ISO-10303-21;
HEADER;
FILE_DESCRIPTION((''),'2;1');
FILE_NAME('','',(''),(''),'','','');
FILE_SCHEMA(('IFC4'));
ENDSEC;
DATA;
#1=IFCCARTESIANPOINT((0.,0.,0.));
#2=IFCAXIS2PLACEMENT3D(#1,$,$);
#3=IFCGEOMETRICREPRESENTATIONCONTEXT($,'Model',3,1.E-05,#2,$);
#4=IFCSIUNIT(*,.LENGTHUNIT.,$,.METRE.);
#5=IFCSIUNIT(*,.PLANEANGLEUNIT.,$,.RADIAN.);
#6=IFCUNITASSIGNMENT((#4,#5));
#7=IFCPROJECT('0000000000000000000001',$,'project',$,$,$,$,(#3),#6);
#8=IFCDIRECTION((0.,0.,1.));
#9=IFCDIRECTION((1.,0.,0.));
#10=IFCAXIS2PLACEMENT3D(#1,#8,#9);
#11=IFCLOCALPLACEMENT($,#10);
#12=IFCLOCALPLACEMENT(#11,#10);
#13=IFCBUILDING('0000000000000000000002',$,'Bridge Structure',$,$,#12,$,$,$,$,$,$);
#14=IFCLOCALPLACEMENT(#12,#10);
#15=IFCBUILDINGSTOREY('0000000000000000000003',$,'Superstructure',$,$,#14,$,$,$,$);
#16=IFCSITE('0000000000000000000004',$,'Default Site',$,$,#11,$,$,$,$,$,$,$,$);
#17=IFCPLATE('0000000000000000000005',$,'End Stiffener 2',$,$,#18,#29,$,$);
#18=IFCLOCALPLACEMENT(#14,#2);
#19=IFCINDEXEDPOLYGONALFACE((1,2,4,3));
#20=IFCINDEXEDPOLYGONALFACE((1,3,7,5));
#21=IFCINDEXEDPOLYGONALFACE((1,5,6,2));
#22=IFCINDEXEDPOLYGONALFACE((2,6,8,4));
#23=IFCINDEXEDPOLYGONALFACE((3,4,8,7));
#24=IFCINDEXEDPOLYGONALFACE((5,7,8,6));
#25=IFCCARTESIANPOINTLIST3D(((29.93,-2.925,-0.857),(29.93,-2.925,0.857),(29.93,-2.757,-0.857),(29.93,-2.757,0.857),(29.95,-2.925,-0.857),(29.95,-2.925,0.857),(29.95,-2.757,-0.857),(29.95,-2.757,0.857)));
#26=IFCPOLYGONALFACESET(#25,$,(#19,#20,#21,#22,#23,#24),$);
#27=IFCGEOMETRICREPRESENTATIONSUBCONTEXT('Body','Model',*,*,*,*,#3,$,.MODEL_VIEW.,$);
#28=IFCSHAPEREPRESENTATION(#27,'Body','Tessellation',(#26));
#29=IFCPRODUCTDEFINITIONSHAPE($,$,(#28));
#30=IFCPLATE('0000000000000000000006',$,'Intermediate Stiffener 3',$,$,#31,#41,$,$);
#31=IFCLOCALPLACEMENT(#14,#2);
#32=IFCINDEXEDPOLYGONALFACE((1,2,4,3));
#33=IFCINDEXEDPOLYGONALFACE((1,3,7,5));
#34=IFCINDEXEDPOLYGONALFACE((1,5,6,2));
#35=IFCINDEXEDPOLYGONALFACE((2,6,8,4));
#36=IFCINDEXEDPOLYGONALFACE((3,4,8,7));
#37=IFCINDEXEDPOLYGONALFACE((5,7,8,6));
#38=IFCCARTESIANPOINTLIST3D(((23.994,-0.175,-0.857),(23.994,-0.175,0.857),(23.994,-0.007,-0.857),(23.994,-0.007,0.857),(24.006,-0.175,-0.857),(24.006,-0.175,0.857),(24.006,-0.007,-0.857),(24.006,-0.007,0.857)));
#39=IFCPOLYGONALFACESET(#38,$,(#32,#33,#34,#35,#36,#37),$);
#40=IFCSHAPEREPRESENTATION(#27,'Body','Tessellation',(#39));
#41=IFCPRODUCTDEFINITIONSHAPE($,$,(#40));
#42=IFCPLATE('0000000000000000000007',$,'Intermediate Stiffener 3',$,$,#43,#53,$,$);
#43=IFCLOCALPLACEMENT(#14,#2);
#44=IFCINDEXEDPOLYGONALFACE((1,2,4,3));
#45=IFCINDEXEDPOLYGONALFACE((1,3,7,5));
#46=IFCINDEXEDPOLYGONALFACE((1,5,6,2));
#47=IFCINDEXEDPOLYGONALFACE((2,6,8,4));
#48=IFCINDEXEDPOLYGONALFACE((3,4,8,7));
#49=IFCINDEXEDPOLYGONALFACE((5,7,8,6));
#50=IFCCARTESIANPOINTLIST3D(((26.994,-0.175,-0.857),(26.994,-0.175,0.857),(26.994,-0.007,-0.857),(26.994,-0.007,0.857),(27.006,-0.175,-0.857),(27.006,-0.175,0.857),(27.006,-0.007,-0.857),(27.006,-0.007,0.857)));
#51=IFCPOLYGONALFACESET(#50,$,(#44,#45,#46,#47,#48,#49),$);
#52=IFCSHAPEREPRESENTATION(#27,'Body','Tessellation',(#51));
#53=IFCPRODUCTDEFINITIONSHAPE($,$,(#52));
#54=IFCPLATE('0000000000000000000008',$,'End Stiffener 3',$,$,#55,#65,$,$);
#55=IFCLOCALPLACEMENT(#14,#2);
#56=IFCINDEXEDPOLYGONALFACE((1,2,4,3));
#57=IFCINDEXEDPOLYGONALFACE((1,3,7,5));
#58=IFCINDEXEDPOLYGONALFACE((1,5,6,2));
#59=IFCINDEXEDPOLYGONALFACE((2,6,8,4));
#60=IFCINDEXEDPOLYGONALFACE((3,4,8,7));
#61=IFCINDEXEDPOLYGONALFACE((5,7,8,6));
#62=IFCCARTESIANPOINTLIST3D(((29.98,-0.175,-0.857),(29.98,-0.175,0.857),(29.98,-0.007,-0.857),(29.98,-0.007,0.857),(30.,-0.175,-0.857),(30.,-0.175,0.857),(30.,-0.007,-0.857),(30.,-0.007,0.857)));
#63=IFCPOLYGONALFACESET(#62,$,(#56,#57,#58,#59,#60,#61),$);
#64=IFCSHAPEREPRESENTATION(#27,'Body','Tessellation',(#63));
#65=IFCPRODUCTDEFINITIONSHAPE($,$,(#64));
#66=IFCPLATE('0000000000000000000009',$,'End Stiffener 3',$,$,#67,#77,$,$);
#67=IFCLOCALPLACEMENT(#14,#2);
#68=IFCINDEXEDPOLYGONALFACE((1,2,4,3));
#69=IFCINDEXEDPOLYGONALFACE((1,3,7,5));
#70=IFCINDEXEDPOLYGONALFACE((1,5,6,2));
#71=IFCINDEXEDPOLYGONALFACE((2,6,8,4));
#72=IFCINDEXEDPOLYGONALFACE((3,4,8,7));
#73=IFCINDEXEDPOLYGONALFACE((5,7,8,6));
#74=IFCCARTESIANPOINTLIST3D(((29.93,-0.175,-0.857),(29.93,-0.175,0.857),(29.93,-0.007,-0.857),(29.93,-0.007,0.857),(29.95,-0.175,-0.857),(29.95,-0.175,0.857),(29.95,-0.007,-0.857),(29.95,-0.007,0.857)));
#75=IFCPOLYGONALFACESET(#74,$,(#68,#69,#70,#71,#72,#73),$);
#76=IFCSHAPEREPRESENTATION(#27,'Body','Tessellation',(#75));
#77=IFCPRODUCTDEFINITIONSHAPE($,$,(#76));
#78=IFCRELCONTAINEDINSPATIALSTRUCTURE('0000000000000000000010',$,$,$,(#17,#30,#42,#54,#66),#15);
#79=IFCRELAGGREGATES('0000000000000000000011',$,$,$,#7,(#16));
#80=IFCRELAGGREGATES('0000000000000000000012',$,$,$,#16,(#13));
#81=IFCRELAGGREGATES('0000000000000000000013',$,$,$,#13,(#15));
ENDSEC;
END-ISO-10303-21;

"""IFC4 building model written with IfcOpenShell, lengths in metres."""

from ifc_helpers import new_model, si_unit, frame, origin, origin_with_axes, origin_2d_with_axis, place, context, subcontext, project, spatial, rectangle, extrude, element, save


model = new_model("IFC4")

# Units and contexts
model_context = context("Model", 3, precision=1e-05, world=origin())
body_context = subcontext(model_context, "Body", "Model", "MODEL_VIEW")
ifc_project = project(units=[si_unit("LENGTHUNIT", "METRE"), si_unit("PLANEANGLEUNIT", "RADIAN")], contexts=[model_context])

# Site, building, storey
site_placement = place(None, origin_with_axes())
site = spatial("IfcSite", under=ifc_project, at=site_placement, Name="Default Site")
building_placement = place(site_placement, origin_with_axes())
building = spatial("IfcBuilding", under=site, at=building_placement, Name="Bridge Structure")
storey_placement = place(building_placement, origin_with_axes())
storey = spatial("IfcBuildingStorey", under=building, at=storey_placement, Name="Superstructure")

# Plates
for number, where, z_axis, x_axis, name in (
    (1, (29.94, -2.841, -0.857), (0.0, 0.0, 1.0), (1.0, 0.0, 0.0), "End Stiffener 2"),
):
    element("IfcPlate", number, at=place(storey_placement, frame(where, z_axis=z_axis, x_axis=x_axis)), inside=storey, Name=name, context=body_context, shape_type="SweptSolid", body=[
        extrude(rectangle(XDim=0.02, YDim=0.168, at=origin_2d_with_axis()), origin_with_axes(), (0.0, 0.0, 1.0), 1.714),
    ])
for number, where, z_axis, x_axis, name in (
    (2, (24.0, -0.091, -0.857), (0.0, 0.0, 1.0), (1.0, 0.0, 0.0), "Intermediate Stiffener 3"),
    (3, (27.0, -0.091, -0.857), (0.0, 0.0, 1.0), (1.0, 0.0, 0.0), "Intermediate Stiffener 3"),
):
    element("IfcPlate", number, at=place(storey_placement, frame(where, z_axis=z_axis, x_axis=x_axis)), inside=storey, Name=name, context=body_context, shape_type="SweptSolid", body=[
        extrude(rectangle(XDim=0.012, YDim=0.168, at=origin_2d_with_axis()), origin_with_axes(), (0.0, 0.0, 1.0), 1.714),
    ])
for number, where, z_axis, x_axis, name in (
    (4, (29.99, -0.091, -0.857), (0.0, 0.0, 1.0), (1.0, 0.0, 0.0), "End Stiffener 3"),
    (5, (29.94, -0.091, -0.857), (0.0, 0.0, 1.0), (1.0, 0.0, 0.0), "End Stiffener 3"),
):
    element("IfcPlate", number, at=place(storey_placement, frame(where, z_axis=z_axis, x_axis=x_axis)), inside=storey, Name=name, context=body_context, shape_type="SweptSolid", body=[
        extrude(rectangle(XDim=0.02, YDim=0.168, at=origin_2d_with_axis()), origin_with_axes(), (0.0, 0.0, 1.0), 1.714),
    ])

save(model, "model.ifc")
